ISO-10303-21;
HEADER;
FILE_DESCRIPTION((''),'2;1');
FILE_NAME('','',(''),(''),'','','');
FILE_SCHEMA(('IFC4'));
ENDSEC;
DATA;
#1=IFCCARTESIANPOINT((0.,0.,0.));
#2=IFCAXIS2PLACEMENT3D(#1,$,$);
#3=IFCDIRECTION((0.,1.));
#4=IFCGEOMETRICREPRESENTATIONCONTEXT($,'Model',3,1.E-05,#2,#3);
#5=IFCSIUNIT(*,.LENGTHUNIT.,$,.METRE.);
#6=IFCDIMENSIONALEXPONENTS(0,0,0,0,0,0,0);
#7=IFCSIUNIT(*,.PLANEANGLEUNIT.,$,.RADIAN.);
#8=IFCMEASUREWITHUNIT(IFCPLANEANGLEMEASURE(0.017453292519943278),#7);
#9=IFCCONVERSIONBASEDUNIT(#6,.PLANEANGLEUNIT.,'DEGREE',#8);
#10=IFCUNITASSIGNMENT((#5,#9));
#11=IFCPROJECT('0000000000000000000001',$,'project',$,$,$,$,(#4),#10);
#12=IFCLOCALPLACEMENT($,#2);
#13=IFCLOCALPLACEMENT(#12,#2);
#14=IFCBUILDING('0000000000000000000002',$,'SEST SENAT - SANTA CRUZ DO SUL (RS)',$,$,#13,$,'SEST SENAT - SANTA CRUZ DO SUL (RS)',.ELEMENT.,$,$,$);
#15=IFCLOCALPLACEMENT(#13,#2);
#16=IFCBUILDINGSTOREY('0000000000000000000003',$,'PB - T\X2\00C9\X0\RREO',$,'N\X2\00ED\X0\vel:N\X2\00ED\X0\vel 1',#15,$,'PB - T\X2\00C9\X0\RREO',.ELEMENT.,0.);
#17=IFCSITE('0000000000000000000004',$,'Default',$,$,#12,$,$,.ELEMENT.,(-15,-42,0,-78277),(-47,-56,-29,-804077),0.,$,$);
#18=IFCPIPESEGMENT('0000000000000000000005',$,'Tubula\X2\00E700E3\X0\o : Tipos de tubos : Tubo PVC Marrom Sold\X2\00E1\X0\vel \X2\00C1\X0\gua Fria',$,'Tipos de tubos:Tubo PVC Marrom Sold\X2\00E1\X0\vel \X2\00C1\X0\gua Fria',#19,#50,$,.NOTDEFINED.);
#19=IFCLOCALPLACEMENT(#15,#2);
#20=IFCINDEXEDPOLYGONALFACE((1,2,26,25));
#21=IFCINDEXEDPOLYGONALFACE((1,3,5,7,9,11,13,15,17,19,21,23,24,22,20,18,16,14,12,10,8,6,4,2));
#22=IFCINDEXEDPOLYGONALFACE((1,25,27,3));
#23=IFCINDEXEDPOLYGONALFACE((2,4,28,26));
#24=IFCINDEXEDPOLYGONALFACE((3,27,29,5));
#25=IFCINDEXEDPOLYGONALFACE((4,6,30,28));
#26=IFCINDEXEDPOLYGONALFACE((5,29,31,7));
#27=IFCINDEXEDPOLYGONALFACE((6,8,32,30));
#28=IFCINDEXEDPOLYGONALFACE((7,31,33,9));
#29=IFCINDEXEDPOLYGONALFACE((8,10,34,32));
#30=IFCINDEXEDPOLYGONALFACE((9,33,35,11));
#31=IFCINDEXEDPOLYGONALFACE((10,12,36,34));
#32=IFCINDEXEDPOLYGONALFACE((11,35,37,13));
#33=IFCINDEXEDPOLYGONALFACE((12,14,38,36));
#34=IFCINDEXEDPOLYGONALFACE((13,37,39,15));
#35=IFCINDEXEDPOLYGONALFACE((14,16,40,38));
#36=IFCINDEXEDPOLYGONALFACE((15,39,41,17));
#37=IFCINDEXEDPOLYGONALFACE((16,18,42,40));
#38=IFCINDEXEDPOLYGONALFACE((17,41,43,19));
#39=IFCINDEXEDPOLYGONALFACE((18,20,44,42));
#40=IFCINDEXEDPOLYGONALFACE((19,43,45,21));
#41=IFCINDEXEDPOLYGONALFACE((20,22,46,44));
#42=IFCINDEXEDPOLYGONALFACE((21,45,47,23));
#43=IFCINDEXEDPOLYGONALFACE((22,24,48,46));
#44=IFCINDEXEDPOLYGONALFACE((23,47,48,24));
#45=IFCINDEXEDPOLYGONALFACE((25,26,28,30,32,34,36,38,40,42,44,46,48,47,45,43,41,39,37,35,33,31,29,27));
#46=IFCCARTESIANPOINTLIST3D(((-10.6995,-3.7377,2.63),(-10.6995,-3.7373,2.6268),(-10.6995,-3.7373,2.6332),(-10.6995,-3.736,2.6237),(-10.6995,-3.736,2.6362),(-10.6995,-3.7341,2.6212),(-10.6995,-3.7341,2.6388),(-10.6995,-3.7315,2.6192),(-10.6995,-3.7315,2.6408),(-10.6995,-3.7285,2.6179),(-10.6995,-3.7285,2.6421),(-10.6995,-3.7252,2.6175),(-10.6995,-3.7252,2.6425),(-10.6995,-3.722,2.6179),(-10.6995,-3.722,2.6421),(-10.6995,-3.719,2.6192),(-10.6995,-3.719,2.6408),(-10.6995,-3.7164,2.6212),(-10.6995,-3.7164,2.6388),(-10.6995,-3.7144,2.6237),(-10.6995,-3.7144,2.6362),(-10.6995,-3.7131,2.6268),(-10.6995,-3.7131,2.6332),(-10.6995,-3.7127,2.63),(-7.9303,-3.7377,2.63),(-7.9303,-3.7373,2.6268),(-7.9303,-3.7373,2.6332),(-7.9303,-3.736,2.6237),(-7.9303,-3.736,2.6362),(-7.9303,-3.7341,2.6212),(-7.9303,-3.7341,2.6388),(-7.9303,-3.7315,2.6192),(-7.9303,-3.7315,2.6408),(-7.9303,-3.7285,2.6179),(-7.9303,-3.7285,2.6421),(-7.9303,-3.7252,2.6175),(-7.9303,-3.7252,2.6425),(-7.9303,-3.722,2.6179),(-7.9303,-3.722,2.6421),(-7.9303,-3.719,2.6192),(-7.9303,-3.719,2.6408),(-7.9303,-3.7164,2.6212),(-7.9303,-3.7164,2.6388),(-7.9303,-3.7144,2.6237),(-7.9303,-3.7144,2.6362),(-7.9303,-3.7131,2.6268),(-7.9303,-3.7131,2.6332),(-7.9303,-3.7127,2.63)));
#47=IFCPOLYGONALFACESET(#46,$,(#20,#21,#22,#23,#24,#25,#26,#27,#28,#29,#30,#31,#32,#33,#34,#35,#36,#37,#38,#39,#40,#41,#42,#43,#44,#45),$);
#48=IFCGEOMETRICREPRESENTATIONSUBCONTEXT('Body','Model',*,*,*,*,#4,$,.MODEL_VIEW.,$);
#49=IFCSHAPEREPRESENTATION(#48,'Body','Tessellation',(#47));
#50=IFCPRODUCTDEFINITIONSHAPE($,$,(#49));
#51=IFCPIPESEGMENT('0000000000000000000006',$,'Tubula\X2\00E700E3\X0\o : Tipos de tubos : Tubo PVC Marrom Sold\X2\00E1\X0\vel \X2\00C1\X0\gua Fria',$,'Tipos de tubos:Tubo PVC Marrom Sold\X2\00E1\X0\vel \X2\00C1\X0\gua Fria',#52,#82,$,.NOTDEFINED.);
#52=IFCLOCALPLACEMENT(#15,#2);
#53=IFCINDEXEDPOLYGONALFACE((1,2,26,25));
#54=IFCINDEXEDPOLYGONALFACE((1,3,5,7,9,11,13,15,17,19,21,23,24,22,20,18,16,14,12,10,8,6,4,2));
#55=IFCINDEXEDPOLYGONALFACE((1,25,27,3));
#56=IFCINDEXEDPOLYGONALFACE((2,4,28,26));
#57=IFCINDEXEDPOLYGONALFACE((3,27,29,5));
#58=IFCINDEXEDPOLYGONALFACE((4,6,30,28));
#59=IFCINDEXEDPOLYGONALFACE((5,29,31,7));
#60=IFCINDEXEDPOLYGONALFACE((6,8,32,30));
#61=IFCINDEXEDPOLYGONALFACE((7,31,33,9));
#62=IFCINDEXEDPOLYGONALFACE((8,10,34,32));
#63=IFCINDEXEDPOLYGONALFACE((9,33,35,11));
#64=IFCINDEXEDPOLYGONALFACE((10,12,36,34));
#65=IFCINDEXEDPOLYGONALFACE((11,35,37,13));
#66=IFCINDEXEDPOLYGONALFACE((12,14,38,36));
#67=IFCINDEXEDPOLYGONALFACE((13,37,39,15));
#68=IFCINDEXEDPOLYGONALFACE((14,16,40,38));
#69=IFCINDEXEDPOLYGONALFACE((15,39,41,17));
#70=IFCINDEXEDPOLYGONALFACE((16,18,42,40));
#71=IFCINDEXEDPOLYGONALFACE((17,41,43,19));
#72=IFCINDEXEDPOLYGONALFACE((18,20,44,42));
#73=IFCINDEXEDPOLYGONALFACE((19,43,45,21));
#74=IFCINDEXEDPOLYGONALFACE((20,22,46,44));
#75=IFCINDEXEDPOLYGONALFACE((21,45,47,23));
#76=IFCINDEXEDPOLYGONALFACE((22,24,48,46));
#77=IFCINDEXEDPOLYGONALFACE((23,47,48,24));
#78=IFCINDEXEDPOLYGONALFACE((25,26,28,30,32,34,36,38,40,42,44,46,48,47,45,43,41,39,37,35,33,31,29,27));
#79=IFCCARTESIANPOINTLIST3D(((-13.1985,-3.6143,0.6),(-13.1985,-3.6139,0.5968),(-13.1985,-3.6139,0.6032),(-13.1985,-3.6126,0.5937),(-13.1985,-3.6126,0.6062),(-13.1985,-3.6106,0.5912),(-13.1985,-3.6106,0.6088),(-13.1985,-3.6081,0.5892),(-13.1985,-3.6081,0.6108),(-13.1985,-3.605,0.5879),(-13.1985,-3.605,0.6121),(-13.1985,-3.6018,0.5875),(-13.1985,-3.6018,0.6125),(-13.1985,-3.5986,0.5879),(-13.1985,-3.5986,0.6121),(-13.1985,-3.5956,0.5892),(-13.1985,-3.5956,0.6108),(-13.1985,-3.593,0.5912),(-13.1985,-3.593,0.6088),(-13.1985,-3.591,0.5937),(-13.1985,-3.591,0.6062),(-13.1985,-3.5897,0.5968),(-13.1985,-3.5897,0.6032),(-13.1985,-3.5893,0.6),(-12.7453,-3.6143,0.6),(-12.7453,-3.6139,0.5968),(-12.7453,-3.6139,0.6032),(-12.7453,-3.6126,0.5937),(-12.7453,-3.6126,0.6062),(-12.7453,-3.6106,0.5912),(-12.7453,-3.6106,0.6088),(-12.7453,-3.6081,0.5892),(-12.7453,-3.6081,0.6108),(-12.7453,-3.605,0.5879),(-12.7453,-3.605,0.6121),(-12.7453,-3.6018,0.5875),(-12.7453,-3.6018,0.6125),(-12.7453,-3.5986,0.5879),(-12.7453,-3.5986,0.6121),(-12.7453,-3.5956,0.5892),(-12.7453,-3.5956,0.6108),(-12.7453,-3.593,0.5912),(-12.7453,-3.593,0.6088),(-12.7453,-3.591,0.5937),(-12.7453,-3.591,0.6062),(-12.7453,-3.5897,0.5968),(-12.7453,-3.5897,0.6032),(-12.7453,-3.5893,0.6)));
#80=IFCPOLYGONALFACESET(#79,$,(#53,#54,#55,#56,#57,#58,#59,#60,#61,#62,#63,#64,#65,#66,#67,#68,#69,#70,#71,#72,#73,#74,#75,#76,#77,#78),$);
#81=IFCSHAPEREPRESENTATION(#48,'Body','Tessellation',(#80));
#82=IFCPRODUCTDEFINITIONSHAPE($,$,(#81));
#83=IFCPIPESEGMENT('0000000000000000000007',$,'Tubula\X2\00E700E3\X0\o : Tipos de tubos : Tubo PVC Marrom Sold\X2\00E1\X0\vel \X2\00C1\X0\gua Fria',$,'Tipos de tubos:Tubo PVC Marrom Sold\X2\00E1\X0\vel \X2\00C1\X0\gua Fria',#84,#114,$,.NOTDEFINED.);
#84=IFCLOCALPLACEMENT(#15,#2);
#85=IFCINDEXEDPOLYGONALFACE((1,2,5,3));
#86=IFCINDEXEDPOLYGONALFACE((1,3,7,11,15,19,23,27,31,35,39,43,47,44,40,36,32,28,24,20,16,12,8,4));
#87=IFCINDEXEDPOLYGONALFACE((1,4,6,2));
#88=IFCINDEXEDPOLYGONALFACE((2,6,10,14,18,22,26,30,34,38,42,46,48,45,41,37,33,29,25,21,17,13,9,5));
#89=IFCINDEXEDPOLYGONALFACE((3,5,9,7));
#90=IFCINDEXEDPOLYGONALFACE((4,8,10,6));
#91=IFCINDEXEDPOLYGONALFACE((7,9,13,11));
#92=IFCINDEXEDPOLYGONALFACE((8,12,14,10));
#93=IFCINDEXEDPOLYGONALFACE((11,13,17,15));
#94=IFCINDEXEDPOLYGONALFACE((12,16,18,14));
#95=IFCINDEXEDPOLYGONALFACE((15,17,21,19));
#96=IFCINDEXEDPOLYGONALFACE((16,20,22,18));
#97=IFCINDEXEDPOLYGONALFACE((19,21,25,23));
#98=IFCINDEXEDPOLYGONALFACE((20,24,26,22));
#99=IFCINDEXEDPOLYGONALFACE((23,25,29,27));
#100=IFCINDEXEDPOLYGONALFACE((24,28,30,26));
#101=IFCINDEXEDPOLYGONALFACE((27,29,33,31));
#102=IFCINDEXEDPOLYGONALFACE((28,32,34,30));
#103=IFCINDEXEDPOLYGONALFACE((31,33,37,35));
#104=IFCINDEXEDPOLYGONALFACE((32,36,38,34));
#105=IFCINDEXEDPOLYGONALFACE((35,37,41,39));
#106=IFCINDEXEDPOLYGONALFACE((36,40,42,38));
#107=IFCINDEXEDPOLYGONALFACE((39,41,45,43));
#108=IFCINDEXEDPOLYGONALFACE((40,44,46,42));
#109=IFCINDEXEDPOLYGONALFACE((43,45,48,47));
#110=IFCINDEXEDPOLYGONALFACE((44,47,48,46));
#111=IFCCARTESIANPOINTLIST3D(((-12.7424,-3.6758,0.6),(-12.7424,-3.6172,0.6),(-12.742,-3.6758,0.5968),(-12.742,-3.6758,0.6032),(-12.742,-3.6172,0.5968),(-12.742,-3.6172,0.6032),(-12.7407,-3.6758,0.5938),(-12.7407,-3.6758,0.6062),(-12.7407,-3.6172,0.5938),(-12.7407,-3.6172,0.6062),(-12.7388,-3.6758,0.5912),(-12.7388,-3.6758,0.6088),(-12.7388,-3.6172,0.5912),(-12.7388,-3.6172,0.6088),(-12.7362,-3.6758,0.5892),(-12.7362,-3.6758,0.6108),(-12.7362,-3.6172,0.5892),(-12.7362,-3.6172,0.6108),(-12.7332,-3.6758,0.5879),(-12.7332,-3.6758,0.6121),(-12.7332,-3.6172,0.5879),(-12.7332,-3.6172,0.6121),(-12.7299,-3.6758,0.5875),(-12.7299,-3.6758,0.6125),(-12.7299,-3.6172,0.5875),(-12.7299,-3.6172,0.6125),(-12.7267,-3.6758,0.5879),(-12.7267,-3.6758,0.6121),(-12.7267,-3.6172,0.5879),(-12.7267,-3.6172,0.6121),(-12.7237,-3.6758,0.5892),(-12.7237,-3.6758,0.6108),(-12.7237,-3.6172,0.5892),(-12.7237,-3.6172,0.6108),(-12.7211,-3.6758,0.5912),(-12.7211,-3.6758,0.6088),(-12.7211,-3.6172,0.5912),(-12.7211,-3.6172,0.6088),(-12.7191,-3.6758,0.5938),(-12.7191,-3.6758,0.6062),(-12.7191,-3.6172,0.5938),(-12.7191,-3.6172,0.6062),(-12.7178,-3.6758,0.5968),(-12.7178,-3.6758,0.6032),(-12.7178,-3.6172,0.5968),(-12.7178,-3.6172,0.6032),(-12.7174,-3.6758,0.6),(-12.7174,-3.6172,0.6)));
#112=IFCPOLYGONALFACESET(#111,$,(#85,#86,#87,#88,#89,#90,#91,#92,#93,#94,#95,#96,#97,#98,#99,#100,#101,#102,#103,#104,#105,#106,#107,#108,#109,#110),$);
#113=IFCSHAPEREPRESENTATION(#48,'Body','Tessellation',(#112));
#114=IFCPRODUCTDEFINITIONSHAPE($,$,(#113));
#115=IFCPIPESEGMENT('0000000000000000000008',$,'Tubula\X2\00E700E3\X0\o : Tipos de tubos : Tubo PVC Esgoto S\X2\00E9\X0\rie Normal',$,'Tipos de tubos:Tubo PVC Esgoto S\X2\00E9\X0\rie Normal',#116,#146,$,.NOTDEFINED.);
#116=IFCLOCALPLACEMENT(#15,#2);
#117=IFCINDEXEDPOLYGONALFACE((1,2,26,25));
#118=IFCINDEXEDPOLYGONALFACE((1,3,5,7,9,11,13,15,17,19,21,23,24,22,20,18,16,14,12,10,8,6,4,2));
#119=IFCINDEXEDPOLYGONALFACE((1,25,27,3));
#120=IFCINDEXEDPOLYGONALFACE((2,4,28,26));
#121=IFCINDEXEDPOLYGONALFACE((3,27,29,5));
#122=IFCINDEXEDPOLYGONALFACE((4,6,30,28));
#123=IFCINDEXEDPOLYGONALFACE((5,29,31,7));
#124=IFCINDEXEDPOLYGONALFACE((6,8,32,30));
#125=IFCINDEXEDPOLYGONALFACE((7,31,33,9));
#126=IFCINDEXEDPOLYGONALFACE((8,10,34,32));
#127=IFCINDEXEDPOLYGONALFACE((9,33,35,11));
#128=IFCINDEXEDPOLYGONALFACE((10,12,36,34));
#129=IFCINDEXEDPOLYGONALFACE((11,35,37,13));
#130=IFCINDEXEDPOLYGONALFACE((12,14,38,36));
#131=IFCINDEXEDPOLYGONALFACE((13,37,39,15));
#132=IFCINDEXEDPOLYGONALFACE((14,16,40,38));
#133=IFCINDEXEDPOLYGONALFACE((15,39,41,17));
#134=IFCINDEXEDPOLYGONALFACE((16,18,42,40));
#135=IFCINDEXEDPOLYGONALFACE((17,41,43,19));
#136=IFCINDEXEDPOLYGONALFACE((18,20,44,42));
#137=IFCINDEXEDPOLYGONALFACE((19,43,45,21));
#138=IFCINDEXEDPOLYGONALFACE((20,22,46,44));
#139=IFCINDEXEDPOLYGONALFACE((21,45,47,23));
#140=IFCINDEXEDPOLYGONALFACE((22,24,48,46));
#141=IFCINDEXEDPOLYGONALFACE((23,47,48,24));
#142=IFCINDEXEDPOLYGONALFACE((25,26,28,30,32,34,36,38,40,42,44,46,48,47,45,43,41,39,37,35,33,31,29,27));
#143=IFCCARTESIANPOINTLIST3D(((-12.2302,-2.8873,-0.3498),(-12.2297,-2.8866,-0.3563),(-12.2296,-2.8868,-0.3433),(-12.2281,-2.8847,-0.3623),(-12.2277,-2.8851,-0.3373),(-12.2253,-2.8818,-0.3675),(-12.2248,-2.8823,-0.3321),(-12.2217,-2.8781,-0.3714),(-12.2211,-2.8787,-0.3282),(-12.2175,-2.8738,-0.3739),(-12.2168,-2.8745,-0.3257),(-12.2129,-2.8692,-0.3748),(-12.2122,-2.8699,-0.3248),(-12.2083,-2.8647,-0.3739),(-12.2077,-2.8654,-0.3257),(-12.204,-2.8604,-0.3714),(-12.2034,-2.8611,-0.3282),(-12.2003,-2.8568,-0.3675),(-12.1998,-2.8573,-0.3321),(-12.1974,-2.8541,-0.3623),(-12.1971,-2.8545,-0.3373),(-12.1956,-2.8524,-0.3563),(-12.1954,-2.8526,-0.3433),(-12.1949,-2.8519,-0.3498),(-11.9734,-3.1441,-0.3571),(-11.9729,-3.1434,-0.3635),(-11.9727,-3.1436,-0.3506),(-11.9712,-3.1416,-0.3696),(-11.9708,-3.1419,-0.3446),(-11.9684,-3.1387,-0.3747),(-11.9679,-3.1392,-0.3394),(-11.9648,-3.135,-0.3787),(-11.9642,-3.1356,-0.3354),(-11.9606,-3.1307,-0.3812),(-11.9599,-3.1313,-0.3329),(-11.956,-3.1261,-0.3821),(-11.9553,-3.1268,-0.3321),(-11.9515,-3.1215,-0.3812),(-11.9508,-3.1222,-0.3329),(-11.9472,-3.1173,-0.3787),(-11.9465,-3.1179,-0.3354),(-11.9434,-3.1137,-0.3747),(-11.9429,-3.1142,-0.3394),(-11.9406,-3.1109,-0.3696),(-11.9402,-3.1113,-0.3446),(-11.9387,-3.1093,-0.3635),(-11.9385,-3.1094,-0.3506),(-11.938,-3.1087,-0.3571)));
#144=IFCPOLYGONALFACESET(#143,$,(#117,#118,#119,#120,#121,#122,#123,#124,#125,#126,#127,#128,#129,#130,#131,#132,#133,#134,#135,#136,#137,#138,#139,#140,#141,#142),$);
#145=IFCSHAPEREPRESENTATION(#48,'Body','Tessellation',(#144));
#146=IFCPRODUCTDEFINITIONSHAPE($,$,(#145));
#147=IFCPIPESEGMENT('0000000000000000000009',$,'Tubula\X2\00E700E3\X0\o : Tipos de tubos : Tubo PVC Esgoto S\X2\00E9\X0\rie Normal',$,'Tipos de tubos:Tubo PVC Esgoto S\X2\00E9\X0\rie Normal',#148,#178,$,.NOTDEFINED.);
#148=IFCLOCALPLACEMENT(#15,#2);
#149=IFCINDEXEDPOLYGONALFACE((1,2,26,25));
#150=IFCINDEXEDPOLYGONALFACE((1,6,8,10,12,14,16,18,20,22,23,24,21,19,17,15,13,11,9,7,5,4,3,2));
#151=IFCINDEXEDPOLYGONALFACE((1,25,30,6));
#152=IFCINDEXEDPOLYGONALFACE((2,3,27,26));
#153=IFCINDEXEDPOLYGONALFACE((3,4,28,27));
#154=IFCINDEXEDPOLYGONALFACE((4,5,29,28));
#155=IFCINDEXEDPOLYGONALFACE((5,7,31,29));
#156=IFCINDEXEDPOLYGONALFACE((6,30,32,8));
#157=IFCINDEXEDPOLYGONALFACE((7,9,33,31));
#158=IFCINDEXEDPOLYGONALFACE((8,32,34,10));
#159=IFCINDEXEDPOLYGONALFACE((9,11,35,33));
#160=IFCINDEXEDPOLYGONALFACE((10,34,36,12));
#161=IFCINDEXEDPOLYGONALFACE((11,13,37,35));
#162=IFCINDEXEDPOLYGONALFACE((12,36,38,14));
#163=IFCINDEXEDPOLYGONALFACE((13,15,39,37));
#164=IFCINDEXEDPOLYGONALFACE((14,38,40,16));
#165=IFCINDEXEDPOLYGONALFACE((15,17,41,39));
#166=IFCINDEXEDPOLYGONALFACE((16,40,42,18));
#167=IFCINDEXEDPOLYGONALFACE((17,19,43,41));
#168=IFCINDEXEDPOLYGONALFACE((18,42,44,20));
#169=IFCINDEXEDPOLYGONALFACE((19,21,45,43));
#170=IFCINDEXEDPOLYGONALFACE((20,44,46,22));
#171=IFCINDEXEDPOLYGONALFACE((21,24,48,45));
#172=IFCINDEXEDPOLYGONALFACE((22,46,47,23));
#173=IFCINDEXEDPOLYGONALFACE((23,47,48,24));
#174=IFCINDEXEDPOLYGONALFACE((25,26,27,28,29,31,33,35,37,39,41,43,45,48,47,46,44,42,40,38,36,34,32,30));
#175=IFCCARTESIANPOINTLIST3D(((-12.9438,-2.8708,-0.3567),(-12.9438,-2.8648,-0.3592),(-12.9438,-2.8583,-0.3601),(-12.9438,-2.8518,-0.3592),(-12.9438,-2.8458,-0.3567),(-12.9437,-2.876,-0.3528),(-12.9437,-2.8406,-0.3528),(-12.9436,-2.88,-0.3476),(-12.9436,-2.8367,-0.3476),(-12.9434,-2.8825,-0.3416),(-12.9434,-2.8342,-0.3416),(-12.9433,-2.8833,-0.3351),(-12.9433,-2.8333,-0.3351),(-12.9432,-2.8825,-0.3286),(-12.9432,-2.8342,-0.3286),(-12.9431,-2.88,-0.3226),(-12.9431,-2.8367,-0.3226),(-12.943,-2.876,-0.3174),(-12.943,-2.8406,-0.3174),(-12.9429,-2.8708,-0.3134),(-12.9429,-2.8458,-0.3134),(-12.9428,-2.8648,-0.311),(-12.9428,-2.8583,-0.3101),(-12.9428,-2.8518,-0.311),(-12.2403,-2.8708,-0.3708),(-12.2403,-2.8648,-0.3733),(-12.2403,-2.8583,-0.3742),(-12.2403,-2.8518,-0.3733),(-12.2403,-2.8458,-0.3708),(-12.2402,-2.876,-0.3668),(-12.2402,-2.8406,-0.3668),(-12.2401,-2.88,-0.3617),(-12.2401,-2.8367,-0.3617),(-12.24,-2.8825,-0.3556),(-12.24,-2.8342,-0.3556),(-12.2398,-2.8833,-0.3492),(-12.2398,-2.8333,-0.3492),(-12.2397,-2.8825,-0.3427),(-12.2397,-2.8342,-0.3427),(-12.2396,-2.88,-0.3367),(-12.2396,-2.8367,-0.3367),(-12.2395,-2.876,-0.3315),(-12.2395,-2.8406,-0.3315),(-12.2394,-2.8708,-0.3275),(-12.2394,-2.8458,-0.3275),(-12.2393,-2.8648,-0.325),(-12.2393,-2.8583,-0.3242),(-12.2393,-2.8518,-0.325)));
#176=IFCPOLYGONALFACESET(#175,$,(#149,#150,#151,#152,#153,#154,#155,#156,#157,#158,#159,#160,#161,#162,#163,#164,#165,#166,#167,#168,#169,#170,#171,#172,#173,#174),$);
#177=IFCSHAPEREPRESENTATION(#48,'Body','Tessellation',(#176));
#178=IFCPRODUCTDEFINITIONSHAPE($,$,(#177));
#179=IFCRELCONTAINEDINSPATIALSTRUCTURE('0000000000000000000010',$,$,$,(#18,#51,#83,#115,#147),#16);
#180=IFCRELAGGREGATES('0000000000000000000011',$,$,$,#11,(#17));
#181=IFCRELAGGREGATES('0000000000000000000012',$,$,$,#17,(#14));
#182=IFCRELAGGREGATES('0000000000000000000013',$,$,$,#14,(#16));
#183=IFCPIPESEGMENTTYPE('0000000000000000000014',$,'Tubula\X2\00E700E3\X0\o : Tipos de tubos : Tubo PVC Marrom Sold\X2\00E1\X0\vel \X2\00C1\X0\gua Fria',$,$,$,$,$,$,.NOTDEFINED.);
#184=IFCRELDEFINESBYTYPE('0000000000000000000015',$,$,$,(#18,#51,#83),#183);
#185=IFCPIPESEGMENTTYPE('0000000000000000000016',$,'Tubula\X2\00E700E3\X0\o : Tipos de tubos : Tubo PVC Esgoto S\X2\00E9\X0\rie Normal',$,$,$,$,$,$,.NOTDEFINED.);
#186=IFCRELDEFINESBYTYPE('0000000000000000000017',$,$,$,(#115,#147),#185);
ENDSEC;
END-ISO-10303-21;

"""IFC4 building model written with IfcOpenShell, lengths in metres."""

from ifc_helpers import new_model, entity, si_unit, converted_unit, direction, frame, origin, place, context, subcontext, project, spatial, arc, indexed_curve, outline, extrude, type_object, element, save


model = new_model("IFC4")

# Units and contexts
model_context = context("Model", 3, precision=1e-05, world=origin(), true_north=direction((0.0, 1.0)))
body_context = subcontext(model_context, "Body", "Model", "MODEL_VIEW")
ifc_project = project(units=[si_unit("LENGTHUNIT", "METRE"), converted_unit("PLANEANGLEUNIT", "DEGREE", entity("IfcPlaneAngleMeasure", 0.017453292519943278), si_unit("PLANEANGLEUNIT", "RADIAN"), dimensions=[0, 0, 0, 0, 0, 0, 0])], contexts=[model_context])

# Site, building, storey
site_placement = place(None, origin())
site = spatial("IfcSite", under=ifc_project, at=site_placement, Name="Default", CompositionType="ELEMENT", RefLatitude=(-15, -42, 0, -78277), RefLongitude=(-47, -56, -29, -804077), RefElevation=0.0)
building_placement = place(site_placement, origin())
building = spatial("IfcBuilding", under=site, at=building_placement, Name="SEST SENAT - SANTA CRUZ DO SUL (RS)", LongName="SEST SENAT - SANTA CRUZ DO SUL (RS)", CompositionType="ELEMENT")
storey_placement = place(building_placement, origin())
storey = spatial("IfcBuildingStorey", under=building, at=storey_placement, Name="PB - TÉRREO", ObjectType="Nível:Nível 1", LongName="PB - TÉRREO", CompositionType="ELEMENT", Elevation=0.0)

# Pipe segments
pipe_segment_type_1 = type_object("IfcPipeSegmentType", Name="Tubulação : Tipos de tubos : Tubo PVC Marrom Soldável Água Fria", PredefinedType="NOTDEFINED")
pipe_segment_1_placement = place(storey_placement, frame((-10.6995, -3.7393, 2.6159)))
element("IfcPipeSegment", 1, at=pipe_segment_1_placement, inside=storey, type_object=pipe_segment_type_1, Name="Tubulação : Tipos de tubos : Tubo PVC Marrom Soldável Água Fria", ObjectType="Tipos de tubos:Tubo PVC Marrom Soldável Água Fria", PredefinedType="NOTDEFINED", context=body_context, shape_type="SweptSolid", body=[
    extrude(outline(indexed_curve([(0.0125, 0.0), (0.0088, 0.0088), (0.0, 0.0125), (-0.0088, 0.0088), (-0.0125, 0.0), (-0.0088, -0.0088), (0.0, -0.0125), (0.0088, -0.0088)], segments=[arc(1, 2, 3), arc(3, 4, 5), arc(5, 6, 7), arc(7, 8, 1)], self_intersect=False)), frame((0.0, 0.0141, 0.0141), z_axis=(1.0, 0.0, 0.0), x_axis=(0.0, -1.0, 0.0)), (0.0, 0.0, 1.0), 2.7692),
])
pipe_segment_2_placement = place(storey_placement, frame((-13.1985, -3.6159, 0.5859)))
element("IfcPipeSegment", 2, at=pipe_segment_2_placement, inside=storey, type_object=pipe_segment_type_1, Name="Tubulação : Tipos de tubos : Tubo PVC Marrom Soldável Água Fria", ObjectType="Tipos de tubos:Tubo PVC Marrom Soldável Água Fria", PredefinedType="NOTDEFINED", context=body_context, shape_type="SweptSolid", body=[
    extrude(outline(indexed_curve([(0.0125, 0.0), (0.0088, 0.0088), (0.0, 0.0125), (-0.0088, 0.0088), (-0.0125, 0.0), (-0.0088, -0.0088), (0.0, -0.0125), (0.0088, -0.0088)], segments=[arc(1, 2, 3), arc(3, 4, 5), arc(5, 6, 7), arc(7, 8, 1)], self_intersect=False)), frame((0.0, 0.0141, 0.0141), z_axis=(1.0, 0.0, 0.0), x_axis=(0.0, -1.0, 0.0)), (0.0, 0.0, 1.0), 0.4532),
])
pipe_segment_3_placement = place(storey_placement, frame((-12.744, -3.6758, 0.5859)))
element("IfcPipeSegment", 3, at=pipe_segment_3_placement, inside=storey, type_object=pipe_segment_type_1, Name="Tubulação : Tipos de tubos : Tubo PVC Marrom Soldável Água Fria", ObjectType="Tipos de tubos:Tubo PVC Marrom Soldável Água Fria", PredefinedType="NOTDEFINED", context=body_context, shape_type="SweptSolid", body=[
    extrude(outline(indexed_curve([(0.0125, 0.0), (0.0088, 0.0088), (0.0, 0.0125), (-0.0088, 0.0088), (-0.0125, 0.0), (-0.0088, -0.0088), (0.0, -0.0125), (0.0088, -0.0088)], segments=[arc(1, 2, 3), arc(3, 4, 5), arc(5, 6, 7), arc(7, 8, 1)], self_intersect=False)), frame((0.0141, 0.0, 0.0141), z_axis=(0.0, 1.0, 0.0), x_axis=(-1.0, 0.0, 0.0)), (0.0, 0.0, 1.0), 0.0586),
])
pipe_segment_type_2 = type_object("IfcPipeSegmentType", Name="Tubulação : Tipos de tubos : Tubo PVC Esgoto Série Normal", PredefinedType="NOTDEFINED")
pipe_segment_4_placement = place(storey_placement, frame((-12.2318, -3.1457, -0.3232)))
element("IfcPipeSegment", 4, at=pipe_segment_4_placement, inside=storey, type_object=pipe_segment_type_2, Name="Tubulação : Tipos de tubos : Tubo PVC Esgoto Série Normal", ObjectType="Tipos de tubos:Tubo PVC Esgoto Série Normal", PredefinedType="NOTDEFINED", context=body_context, shape_type="SweptSolid", body=[
    extrude(outline(indexed_curve([(0.025, 0.0), (0.0177, 0.0177), (0.0, 0.025), (-0.0177, 0.0177), (-0.025, 0.0), (-0.0177, -0.0177), (0.0, -0.025), (0.0177, -0.0177)], segments=[arc(1, 2, 3), arc(3, 4, 5), arc(5, 6, 7), arc(7, 8, 1)], self_intersect=False)), frame((0.0193, 0.2761, -0.0266), z_axis=(0.707036, -0.706895, -0.019996), x_axis=(-0.707036, -0.707178, 0.0)), (0.0, 0.0, 1.0), 0.3633),
])
pipe_segment_5_placement = place(storey_placement, frame((-12.9454, -2.8849, -0.3085)))
element("IfcPipeSegment", 5, at=pipe_segment_5_placement, inside=storey, type_object=pipe_segment_type_2, Name="Tubulação : Tipos de tubos : Tubo PVC Esgoto Série Normal", ObjectType="Tipos de tubos:Tubo PVC Esgoto Série Normal", PredefinedType="NOTDEFINED", context=body_context, shape_type="SweptSolid", body=[
    extrude(outline(indexed_curve([(0.025, 0.0), (0.0177, 0.0177), (0.0, 0.025), (-0.0177, 0.0177), (-0.025, 0.0), (-0.0177, -0.0177), (0.0, -0.025), (0.0177, -0.0177)], segments=[arc(1, 2, 3), arc(3, 4, 5), arc(5, 6, 7), arc(7, 8, 1)], self_intersect=False)), frame((0.0021, 0.0266, -0.0266), z_axis=(0.9998, 0.0, -0.019996), x_axis=(0.0, 1.0, 0.0)), (0.0, 0.0, 1.0), 0.7036),
])

save(model, "model.ifc")
